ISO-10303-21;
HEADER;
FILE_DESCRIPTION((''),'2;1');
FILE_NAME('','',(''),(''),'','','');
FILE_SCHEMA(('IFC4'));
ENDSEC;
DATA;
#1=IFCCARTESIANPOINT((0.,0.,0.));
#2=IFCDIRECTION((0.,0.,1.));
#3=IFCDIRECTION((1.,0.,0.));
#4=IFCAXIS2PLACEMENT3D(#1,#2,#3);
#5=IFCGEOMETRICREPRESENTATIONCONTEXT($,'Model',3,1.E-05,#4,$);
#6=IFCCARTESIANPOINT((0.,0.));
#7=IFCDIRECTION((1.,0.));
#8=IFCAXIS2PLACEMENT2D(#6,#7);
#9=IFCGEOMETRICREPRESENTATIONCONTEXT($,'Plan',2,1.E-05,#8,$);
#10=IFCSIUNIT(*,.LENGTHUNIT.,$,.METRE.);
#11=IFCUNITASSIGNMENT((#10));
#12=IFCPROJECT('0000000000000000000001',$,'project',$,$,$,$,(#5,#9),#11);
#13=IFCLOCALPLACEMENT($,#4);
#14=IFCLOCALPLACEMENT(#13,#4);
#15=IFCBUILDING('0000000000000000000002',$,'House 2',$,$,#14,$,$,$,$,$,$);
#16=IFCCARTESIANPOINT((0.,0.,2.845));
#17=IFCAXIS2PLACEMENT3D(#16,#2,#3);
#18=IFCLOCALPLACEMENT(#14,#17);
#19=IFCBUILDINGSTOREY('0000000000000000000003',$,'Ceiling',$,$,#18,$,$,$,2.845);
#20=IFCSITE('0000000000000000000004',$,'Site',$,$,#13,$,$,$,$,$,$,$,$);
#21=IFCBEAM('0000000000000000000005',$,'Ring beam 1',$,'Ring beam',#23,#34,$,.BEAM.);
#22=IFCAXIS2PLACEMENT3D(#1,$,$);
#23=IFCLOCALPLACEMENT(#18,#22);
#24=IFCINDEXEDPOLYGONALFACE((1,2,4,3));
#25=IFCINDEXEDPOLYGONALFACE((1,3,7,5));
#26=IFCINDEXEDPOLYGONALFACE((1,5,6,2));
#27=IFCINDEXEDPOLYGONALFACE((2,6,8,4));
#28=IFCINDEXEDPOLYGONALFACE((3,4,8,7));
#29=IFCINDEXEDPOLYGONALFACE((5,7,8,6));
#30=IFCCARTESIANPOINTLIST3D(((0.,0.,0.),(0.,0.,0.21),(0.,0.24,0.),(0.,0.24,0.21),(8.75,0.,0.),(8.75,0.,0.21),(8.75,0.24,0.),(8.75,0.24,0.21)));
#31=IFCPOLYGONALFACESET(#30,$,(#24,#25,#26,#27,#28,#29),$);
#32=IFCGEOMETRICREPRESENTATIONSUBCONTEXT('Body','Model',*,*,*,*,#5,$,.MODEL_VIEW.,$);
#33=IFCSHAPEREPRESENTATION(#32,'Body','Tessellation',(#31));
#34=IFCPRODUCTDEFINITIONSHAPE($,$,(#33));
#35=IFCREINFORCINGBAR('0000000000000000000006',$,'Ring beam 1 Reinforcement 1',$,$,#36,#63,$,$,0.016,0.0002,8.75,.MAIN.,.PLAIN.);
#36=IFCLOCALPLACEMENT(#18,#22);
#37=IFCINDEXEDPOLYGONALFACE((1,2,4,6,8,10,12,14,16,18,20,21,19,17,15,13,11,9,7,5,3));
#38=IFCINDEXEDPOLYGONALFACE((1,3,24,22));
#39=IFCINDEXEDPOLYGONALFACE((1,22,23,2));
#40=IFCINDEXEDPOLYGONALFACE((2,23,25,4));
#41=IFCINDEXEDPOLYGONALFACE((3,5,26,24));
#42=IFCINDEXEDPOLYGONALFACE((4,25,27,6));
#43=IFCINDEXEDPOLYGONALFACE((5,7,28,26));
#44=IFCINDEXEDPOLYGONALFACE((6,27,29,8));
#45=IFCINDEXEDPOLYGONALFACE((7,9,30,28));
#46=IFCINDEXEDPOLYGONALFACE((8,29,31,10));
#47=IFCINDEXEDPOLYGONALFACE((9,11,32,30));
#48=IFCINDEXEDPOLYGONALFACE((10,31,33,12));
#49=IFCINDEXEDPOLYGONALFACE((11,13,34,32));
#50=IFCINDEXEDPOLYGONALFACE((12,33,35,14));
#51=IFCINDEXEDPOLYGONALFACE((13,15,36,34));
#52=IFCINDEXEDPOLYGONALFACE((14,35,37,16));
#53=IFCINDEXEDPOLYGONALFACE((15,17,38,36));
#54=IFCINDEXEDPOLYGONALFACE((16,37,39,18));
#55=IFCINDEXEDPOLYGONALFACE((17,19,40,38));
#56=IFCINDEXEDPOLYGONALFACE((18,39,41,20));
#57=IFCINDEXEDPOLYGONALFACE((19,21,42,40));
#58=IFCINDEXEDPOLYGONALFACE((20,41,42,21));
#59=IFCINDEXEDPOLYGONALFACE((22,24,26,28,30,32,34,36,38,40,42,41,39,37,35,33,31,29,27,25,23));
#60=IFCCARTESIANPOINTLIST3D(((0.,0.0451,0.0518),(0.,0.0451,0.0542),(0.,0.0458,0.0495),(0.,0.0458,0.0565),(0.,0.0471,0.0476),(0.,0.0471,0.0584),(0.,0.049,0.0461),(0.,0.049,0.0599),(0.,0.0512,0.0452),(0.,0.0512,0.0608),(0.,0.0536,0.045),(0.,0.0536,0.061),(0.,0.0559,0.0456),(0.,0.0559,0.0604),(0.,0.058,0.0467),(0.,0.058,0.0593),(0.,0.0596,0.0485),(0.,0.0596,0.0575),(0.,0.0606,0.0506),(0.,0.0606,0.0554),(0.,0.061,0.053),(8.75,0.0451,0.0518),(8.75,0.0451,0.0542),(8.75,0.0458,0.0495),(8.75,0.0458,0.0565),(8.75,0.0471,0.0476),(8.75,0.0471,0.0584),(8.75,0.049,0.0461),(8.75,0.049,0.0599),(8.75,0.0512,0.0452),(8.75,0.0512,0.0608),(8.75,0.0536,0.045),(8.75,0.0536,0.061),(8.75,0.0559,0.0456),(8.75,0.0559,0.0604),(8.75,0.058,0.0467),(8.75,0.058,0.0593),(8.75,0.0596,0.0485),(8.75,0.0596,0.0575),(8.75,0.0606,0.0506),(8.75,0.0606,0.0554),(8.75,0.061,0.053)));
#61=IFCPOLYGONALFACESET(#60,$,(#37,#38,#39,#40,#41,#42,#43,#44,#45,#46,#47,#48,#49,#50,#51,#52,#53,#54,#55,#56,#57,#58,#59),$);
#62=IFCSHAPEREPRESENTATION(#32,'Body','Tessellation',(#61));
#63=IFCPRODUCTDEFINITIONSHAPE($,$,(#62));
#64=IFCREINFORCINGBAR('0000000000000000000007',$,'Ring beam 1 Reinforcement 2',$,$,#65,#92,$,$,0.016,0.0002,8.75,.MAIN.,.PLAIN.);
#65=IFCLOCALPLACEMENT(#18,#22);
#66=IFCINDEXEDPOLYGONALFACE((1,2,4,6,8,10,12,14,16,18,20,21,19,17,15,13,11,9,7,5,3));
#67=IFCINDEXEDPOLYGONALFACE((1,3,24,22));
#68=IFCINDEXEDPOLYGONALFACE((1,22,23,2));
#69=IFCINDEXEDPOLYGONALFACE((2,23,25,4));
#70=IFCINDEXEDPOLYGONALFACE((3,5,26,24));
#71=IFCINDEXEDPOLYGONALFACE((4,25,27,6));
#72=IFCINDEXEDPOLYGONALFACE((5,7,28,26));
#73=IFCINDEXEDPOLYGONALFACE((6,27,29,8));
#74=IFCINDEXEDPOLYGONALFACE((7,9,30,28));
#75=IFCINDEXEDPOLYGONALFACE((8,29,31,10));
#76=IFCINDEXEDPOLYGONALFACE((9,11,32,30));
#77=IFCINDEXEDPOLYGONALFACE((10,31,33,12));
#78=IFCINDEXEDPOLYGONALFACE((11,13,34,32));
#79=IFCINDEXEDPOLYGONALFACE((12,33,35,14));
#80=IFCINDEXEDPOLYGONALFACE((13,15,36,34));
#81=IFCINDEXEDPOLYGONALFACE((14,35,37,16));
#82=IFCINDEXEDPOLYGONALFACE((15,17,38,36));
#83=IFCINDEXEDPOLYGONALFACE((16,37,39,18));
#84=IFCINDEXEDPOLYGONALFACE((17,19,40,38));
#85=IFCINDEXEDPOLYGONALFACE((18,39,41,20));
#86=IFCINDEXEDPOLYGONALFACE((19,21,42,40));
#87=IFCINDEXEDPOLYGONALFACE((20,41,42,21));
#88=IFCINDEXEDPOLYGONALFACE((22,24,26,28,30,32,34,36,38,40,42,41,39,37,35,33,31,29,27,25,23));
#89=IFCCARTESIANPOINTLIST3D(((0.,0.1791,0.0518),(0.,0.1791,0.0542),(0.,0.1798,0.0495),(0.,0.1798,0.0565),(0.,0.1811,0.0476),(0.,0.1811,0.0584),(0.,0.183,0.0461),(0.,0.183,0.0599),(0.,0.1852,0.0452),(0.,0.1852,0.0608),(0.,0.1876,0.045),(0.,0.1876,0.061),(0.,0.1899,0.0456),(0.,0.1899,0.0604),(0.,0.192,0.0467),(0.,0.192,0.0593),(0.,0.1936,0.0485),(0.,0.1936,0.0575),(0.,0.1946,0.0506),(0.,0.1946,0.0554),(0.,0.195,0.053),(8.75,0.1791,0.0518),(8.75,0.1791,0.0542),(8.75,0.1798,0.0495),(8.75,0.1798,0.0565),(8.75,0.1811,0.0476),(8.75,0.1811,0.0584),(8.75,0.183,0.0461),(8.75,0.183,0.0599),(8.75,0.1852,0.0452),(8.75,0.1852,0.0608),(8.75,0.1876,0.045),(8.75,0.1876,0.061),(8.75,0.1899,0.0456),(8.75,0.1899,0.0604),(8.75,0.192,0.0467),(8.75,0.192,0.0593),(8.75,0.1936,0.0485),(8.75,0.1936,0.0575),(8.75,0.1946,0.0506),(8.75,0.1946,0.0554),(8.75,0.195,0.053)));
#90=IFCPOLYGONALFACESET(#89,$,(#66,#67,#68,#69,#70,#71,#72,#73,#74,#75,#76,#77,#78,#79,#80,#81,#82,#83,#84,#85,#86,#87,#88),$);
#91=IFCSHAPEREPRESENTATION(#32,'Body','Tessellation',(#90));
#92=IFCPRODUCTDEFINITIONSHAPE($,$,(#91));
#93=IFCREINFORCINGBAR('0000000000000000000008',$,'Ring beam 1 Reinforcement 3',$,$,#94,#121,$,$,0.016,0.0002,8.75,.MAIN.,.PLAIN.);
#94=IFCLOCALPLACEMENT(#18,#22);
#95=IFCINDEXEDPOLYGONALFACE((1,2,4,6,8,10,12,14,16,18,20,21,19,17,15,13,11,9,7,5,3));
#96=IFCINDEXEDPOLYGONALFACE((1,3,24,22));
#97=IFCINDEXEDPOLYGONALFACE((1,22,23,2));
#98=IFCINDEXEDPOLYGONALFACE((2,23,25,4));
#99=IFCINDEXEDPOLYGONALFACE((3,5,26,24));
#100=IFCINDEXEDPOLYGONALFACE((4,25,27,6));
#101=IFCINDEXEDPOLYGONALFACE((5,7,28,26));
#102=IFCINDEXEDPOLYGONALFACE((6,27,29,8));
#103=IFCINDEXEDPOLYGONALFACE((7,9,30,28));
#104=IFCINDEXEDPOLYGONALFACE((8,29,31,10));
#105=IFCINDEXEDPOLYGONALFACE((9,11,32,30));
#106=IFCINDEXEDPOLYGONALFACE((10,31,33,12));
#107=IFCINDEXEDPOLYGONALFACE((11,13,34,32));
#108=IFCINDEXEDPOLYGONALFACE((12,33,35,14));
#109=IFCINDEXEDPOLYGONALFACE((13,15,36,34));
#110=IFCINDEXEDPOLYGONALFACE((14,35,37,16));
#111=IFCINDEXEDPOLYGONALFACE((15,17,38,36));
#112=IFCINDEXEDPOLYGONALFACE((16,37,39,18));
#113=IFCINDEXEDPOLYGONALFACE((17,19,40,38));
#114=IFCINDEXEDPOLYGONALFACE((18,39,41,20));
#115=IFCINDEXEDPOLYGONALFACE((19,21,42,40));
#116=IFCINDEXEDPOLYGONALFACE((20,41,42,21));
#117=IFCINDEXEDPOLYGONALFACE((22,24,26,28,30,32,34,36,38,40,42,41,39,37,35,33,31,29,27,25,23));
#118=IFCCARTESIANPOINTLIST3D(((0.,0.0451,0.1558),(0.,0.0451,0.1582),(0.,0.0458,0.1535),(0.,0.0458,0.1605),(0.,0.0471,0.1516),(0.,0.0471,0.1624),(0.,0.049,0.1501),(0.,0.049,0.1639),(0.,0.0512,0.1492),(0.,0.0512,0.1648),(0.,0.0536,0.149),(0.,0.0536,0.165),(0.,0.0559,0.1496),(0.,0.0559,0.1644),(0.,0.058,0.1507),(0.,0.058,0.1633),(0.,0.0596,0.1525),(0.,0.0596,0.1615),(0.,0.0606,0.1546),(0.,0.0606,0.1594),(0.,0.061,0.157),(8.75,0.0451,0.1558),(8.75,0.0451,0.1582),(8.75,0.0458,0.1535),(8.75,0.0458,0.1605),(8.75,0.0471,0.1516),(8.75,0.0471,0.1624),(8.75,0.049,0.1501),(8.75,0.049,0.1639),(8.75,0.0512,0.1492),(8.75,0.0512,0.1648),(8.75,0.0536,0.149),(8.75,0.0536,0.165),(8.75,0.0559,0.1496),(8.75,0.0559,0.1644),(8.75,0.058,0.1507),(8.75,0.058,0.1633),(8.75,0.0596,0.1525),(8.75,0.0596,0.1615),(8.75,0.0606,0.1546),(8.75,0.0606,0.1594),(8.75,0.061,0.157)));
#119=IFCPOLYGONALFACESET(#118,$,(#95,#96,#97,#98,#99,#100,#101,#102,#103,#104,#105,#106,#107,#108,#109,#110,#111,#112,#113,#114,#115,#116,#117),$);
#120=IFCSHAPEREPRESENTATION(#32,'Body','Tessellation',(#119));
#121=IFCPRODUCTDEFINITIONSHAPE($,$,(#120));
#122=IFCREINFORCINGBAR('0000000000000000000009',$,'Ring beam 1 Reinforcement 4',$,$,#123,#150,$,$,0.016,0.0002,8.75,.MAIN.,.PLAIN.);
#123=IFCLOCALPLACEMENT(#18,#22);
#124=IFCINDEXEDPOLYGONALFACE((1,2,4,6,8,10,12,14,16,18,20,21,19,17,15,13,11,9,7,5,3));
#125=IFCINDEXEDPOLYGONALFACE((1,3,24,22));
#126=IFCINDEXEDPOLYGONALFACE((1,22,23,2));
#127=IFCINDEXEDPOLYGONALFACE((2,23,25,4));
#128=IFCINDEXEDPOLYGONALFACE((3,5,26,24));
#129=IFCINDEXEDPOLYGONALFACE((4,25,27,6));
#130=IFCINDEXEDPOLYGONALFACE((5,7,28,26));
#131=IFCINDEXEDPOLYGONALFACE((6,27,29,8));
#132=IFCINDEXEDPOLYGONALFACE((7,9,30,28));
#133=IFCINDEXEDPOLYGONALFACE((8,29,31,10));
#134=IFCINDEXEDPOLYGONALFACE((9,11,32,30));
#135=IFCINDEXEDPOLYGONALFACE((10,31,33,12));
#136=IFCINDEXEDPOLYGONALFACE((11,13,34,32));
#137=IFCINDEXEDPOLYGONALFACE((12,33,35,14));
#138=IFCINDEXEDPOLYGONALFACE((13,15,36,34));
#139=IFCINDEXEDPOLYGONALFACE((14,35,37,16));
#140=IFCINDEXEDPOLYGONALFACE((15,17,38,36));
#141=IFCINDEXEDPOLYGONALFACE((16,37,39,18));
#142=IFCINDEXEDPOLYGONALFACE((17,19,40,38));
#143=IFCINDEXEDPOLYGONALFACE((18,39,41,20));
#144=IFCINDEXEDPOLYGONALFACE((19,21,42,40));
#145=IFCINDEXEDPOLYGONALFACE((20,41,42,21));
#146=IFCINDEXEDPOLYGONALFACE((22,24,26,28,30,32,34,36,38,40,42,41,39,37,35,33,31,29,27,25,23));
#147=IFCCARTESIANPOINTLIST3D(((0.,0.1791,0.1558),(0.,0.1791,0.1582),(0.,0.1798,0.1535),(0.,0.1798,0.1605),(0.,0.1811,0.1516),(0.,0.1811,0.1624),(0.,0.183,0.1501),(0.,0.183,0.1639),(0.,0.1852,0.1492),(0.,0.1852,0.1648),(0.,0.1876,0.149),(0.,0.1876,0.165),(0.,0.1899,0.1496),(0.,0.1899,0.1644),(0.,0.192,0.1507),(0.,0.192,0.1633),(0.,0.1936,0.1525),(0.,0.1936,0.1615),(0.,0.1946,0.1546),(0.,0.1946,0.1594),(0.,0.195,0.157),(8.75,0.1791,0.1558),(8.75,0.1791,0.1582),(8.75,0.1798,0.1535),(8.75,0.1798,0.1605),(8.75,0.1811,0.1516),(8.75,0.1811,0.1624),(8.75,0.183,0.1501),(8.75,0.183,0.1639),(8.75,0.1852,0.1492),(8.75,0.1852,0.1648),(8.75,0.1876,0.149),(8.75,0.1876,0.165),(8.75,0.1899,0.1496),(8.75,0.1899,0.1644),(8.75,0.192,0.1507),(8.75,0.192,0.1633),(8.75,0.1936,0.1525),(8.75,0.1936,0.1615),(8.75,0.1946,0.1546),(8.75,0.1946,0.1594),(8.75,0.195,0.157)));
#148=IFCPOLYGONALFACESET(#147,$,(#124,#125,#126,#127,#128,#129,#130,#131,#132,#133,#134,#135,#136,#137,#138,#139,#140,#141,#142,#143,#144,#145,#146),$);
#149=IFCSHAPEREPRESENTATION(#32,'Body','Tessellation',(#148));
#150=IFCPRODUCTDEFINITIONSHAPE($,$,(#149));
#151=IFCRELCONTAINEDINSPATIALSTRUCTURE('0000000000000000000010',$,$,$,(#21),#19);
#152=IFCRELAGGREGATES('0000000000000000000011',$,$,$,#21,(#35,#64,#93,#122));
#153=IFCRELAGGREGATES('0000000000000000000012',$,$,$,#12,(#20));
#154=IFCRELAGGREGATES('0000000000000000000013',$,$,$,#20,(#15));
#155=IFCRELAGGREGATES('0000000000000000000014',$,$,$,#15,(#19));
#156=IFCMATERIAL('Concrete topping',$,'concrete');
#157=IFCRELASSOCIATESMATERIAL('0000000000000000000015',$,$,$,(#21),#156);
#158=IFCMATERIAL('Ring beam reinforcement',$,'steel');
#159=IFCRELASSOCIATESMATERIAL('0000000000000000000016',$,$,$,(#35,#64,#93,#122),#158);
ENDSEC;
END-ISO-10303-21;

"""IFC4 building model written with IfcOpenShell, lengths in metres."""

from ifc_helpers import new_model, si_unit, frame, origin_with_axes, origin_2d, origin_2d_with_axis, place, context, subcontext, project, spatial, circle_curve, rectangle, outline, extrude, material, element, aggregate, save


model = new_model("IFC4")

# Units and contexts
model_context = context("Model", 3, precision=1e-05, world=origin_with_axes())
plan_context = context("Plan", 2, precision=1e-05, world=origin_2d_with_axis())
body_context = subcontext(model_context, "Body", "Model", "MODEL_VIEW")
ifc_project = project(units=[si_unit("LENGTHUNIT", "METRE")], contexts=[model_context, plan_context])

# Site, building, storey
site_placement = place(None, origin_with_axes())
site = spatial("IfcSite", under=ifc_project, at=site_placement, Name="Site")
building_placement = place(site_placement, origin_with_axes())
building = spatial("IfcBuilding", under=site, at=building_placement, Name="House 2")
storey_placement = place(building_placement, frame((0.0, 0.0, 2.845), z_axis=(0.0, 0.0, 1.0), x_axis=(1.0, 0.0, 0.0)))
storey = spatial("IfcBuildingStorey", under=building, at=storey_placement, Name="Ceiling", Elevation=2.845)

# Beam
ifc_material_1 = material(Name="Concrete topping", Category="concrete")
beam_1_placement = place(storey_placement, frame((0.0, 0.12, 0.105), z_axis=(0.0, 0.0, 1.0), x_axis=(1.0, 0.0, 0.0)))
beam_1 = element("IfcBeam", 1, at=beam_1_placement, inside=storey, material=ifc_material_1, Name="Ring beam 1", ObjectType="Ring beam", PredefinedType="BEAM", context=body_context, shape_type="SweptSolid", body=[
    extrude(rectangle(XDim=0.24, YDim=0.21), frame((0.0, 0.0, 0.0), z_axis=(1.0, 0.0, 0.0), x_axis=(0.0, 1.0, 0.0)), (0.0, 0.0, 1.0), 8.75),
])

# Reinforcing bars
ifc_material_2 = material(Name="Ring beam reinforcement", Category="steel")
reinforcing_bar_1_placement = place(beam_1_placement, frame((0.0, -0.067, -0.052), z_axis=(0.0, 0.0, 1.0), x_axis=(1.0, 0.0, 0.0)))
reinforcing_bar_1 = element("IfcReinforcingBar", 2, at=reinforcing_bar_1_placement, material=ifc_material_2, Name="Ring beam 1 Reinforcement 1", BarLength=8.75, BarSurface="PLAIN", CrossSectionArea=0.0002, NominalDiameter=0.016, PredefinedType="MAIN", context=body_context, shape_type="SweptSolid", body=[
    extrude(outline(circle_curve(origin_2d(), 0.008)), frame((0.0, 0.0, 0.0), z_axis=(1.0, 0.0, 0.0), x_axis=(0.0, 1.0, 0.0)), (0.0, 0.0, 1.0), 8.75),
])
reinforcing_bar_2_placement = place(beam_1_placement, frame((0.0, 0.067, -0.052), z_axis=(0.0, 0.0, 1.0), x_axis=(1.0, 0.0, 0.0)))
reinforcing_bar_2 = element("IfcReinforcingBar", 3, at=reinforcing_bar_2_placement, material=ifc_material_2, Name="Ring beam 1 Reinforcement 2", BarLength=8.75, BarSurface="PLAIN", CrossSectionArea=0.0002, NominalDiameter=0.016, PredefinedType="MAIN", context=body_context, shape_type="SweptSolid", body=[
    extrude(outline(circle_curve(origin_2d(), 0.008)), frame((0.0, 0.0, 0.0), z_axis=(1.0, 0.0, 0.0), x_axis=(0.0, 1.0, 0.0)), (0.0, 0.0, 1.0), 8.75),
])
reinforcing_bar_3_placement = place(beam_1_placement, frame((0.0, -0.067, 0.052), z_axis=(0.0, 0.0, 1.0), x_axis=(1.0, 0.0, 0.0)))
reinforcing_bar_3 = element("IfcReinforcingBar", 4, at=reinforcing_bar_3_placement, material=ifc_material_2, Name="Ring beam 1 Reinforcement 3", BarLength=8.75, BarSurface="PLAIN", CrossSectionArea=0.0002, NominalDiameter=0.016, PredefinedType="MAIN", context=body_context, shape_type="SweptSolid", body=[
    extrude(outline(circle_curve(origin_2d(), 0.008)), frame((0.0, 0.0, 0.0), z_axis=(1.0, 0.0, 0.0), x_axis=(0.0, 1.0, 0.0)), (0.0, 0.0, 1.0), 8.75),
])
reinforcing_bar_4_placement = place(beam_1_placement, frame((0.0, 0.067, 0.052), z_axis=(0.0, 0.0, 1.0), x_axis=(1.0, 0.0, 0.0)))
reinforcing_bar_4 = element("IfcReinforcingBar", 5, at=reinforcing_bar_4_placement, material=ifc_material_2, Name="Ring beam 1 Reinforcement 4", BarLength=8.75, BarSurface="PLAIN", CrossSectionArea=0.0002, NominalDiameter=0.016, PredefinedType="MAIN", context=body_context, shape_type="SweptSolid", body=[
    extrude(outline(circle_curve(origin_2d(), 0.008)), frame((0.0, 0.0, 0.0), z_axis=(1.0, 0.0, 0.0), x_axis=(0.0, 1.0, 0.0)), (0.0, 0.0, 1.0), 8.75),
])
aggregate(beam_1, [reinforcing_bar_1, reinforcing_bar_2, reinforcing_bar_3, reinforcing_bar_4])

save(model, "model.ifc")
